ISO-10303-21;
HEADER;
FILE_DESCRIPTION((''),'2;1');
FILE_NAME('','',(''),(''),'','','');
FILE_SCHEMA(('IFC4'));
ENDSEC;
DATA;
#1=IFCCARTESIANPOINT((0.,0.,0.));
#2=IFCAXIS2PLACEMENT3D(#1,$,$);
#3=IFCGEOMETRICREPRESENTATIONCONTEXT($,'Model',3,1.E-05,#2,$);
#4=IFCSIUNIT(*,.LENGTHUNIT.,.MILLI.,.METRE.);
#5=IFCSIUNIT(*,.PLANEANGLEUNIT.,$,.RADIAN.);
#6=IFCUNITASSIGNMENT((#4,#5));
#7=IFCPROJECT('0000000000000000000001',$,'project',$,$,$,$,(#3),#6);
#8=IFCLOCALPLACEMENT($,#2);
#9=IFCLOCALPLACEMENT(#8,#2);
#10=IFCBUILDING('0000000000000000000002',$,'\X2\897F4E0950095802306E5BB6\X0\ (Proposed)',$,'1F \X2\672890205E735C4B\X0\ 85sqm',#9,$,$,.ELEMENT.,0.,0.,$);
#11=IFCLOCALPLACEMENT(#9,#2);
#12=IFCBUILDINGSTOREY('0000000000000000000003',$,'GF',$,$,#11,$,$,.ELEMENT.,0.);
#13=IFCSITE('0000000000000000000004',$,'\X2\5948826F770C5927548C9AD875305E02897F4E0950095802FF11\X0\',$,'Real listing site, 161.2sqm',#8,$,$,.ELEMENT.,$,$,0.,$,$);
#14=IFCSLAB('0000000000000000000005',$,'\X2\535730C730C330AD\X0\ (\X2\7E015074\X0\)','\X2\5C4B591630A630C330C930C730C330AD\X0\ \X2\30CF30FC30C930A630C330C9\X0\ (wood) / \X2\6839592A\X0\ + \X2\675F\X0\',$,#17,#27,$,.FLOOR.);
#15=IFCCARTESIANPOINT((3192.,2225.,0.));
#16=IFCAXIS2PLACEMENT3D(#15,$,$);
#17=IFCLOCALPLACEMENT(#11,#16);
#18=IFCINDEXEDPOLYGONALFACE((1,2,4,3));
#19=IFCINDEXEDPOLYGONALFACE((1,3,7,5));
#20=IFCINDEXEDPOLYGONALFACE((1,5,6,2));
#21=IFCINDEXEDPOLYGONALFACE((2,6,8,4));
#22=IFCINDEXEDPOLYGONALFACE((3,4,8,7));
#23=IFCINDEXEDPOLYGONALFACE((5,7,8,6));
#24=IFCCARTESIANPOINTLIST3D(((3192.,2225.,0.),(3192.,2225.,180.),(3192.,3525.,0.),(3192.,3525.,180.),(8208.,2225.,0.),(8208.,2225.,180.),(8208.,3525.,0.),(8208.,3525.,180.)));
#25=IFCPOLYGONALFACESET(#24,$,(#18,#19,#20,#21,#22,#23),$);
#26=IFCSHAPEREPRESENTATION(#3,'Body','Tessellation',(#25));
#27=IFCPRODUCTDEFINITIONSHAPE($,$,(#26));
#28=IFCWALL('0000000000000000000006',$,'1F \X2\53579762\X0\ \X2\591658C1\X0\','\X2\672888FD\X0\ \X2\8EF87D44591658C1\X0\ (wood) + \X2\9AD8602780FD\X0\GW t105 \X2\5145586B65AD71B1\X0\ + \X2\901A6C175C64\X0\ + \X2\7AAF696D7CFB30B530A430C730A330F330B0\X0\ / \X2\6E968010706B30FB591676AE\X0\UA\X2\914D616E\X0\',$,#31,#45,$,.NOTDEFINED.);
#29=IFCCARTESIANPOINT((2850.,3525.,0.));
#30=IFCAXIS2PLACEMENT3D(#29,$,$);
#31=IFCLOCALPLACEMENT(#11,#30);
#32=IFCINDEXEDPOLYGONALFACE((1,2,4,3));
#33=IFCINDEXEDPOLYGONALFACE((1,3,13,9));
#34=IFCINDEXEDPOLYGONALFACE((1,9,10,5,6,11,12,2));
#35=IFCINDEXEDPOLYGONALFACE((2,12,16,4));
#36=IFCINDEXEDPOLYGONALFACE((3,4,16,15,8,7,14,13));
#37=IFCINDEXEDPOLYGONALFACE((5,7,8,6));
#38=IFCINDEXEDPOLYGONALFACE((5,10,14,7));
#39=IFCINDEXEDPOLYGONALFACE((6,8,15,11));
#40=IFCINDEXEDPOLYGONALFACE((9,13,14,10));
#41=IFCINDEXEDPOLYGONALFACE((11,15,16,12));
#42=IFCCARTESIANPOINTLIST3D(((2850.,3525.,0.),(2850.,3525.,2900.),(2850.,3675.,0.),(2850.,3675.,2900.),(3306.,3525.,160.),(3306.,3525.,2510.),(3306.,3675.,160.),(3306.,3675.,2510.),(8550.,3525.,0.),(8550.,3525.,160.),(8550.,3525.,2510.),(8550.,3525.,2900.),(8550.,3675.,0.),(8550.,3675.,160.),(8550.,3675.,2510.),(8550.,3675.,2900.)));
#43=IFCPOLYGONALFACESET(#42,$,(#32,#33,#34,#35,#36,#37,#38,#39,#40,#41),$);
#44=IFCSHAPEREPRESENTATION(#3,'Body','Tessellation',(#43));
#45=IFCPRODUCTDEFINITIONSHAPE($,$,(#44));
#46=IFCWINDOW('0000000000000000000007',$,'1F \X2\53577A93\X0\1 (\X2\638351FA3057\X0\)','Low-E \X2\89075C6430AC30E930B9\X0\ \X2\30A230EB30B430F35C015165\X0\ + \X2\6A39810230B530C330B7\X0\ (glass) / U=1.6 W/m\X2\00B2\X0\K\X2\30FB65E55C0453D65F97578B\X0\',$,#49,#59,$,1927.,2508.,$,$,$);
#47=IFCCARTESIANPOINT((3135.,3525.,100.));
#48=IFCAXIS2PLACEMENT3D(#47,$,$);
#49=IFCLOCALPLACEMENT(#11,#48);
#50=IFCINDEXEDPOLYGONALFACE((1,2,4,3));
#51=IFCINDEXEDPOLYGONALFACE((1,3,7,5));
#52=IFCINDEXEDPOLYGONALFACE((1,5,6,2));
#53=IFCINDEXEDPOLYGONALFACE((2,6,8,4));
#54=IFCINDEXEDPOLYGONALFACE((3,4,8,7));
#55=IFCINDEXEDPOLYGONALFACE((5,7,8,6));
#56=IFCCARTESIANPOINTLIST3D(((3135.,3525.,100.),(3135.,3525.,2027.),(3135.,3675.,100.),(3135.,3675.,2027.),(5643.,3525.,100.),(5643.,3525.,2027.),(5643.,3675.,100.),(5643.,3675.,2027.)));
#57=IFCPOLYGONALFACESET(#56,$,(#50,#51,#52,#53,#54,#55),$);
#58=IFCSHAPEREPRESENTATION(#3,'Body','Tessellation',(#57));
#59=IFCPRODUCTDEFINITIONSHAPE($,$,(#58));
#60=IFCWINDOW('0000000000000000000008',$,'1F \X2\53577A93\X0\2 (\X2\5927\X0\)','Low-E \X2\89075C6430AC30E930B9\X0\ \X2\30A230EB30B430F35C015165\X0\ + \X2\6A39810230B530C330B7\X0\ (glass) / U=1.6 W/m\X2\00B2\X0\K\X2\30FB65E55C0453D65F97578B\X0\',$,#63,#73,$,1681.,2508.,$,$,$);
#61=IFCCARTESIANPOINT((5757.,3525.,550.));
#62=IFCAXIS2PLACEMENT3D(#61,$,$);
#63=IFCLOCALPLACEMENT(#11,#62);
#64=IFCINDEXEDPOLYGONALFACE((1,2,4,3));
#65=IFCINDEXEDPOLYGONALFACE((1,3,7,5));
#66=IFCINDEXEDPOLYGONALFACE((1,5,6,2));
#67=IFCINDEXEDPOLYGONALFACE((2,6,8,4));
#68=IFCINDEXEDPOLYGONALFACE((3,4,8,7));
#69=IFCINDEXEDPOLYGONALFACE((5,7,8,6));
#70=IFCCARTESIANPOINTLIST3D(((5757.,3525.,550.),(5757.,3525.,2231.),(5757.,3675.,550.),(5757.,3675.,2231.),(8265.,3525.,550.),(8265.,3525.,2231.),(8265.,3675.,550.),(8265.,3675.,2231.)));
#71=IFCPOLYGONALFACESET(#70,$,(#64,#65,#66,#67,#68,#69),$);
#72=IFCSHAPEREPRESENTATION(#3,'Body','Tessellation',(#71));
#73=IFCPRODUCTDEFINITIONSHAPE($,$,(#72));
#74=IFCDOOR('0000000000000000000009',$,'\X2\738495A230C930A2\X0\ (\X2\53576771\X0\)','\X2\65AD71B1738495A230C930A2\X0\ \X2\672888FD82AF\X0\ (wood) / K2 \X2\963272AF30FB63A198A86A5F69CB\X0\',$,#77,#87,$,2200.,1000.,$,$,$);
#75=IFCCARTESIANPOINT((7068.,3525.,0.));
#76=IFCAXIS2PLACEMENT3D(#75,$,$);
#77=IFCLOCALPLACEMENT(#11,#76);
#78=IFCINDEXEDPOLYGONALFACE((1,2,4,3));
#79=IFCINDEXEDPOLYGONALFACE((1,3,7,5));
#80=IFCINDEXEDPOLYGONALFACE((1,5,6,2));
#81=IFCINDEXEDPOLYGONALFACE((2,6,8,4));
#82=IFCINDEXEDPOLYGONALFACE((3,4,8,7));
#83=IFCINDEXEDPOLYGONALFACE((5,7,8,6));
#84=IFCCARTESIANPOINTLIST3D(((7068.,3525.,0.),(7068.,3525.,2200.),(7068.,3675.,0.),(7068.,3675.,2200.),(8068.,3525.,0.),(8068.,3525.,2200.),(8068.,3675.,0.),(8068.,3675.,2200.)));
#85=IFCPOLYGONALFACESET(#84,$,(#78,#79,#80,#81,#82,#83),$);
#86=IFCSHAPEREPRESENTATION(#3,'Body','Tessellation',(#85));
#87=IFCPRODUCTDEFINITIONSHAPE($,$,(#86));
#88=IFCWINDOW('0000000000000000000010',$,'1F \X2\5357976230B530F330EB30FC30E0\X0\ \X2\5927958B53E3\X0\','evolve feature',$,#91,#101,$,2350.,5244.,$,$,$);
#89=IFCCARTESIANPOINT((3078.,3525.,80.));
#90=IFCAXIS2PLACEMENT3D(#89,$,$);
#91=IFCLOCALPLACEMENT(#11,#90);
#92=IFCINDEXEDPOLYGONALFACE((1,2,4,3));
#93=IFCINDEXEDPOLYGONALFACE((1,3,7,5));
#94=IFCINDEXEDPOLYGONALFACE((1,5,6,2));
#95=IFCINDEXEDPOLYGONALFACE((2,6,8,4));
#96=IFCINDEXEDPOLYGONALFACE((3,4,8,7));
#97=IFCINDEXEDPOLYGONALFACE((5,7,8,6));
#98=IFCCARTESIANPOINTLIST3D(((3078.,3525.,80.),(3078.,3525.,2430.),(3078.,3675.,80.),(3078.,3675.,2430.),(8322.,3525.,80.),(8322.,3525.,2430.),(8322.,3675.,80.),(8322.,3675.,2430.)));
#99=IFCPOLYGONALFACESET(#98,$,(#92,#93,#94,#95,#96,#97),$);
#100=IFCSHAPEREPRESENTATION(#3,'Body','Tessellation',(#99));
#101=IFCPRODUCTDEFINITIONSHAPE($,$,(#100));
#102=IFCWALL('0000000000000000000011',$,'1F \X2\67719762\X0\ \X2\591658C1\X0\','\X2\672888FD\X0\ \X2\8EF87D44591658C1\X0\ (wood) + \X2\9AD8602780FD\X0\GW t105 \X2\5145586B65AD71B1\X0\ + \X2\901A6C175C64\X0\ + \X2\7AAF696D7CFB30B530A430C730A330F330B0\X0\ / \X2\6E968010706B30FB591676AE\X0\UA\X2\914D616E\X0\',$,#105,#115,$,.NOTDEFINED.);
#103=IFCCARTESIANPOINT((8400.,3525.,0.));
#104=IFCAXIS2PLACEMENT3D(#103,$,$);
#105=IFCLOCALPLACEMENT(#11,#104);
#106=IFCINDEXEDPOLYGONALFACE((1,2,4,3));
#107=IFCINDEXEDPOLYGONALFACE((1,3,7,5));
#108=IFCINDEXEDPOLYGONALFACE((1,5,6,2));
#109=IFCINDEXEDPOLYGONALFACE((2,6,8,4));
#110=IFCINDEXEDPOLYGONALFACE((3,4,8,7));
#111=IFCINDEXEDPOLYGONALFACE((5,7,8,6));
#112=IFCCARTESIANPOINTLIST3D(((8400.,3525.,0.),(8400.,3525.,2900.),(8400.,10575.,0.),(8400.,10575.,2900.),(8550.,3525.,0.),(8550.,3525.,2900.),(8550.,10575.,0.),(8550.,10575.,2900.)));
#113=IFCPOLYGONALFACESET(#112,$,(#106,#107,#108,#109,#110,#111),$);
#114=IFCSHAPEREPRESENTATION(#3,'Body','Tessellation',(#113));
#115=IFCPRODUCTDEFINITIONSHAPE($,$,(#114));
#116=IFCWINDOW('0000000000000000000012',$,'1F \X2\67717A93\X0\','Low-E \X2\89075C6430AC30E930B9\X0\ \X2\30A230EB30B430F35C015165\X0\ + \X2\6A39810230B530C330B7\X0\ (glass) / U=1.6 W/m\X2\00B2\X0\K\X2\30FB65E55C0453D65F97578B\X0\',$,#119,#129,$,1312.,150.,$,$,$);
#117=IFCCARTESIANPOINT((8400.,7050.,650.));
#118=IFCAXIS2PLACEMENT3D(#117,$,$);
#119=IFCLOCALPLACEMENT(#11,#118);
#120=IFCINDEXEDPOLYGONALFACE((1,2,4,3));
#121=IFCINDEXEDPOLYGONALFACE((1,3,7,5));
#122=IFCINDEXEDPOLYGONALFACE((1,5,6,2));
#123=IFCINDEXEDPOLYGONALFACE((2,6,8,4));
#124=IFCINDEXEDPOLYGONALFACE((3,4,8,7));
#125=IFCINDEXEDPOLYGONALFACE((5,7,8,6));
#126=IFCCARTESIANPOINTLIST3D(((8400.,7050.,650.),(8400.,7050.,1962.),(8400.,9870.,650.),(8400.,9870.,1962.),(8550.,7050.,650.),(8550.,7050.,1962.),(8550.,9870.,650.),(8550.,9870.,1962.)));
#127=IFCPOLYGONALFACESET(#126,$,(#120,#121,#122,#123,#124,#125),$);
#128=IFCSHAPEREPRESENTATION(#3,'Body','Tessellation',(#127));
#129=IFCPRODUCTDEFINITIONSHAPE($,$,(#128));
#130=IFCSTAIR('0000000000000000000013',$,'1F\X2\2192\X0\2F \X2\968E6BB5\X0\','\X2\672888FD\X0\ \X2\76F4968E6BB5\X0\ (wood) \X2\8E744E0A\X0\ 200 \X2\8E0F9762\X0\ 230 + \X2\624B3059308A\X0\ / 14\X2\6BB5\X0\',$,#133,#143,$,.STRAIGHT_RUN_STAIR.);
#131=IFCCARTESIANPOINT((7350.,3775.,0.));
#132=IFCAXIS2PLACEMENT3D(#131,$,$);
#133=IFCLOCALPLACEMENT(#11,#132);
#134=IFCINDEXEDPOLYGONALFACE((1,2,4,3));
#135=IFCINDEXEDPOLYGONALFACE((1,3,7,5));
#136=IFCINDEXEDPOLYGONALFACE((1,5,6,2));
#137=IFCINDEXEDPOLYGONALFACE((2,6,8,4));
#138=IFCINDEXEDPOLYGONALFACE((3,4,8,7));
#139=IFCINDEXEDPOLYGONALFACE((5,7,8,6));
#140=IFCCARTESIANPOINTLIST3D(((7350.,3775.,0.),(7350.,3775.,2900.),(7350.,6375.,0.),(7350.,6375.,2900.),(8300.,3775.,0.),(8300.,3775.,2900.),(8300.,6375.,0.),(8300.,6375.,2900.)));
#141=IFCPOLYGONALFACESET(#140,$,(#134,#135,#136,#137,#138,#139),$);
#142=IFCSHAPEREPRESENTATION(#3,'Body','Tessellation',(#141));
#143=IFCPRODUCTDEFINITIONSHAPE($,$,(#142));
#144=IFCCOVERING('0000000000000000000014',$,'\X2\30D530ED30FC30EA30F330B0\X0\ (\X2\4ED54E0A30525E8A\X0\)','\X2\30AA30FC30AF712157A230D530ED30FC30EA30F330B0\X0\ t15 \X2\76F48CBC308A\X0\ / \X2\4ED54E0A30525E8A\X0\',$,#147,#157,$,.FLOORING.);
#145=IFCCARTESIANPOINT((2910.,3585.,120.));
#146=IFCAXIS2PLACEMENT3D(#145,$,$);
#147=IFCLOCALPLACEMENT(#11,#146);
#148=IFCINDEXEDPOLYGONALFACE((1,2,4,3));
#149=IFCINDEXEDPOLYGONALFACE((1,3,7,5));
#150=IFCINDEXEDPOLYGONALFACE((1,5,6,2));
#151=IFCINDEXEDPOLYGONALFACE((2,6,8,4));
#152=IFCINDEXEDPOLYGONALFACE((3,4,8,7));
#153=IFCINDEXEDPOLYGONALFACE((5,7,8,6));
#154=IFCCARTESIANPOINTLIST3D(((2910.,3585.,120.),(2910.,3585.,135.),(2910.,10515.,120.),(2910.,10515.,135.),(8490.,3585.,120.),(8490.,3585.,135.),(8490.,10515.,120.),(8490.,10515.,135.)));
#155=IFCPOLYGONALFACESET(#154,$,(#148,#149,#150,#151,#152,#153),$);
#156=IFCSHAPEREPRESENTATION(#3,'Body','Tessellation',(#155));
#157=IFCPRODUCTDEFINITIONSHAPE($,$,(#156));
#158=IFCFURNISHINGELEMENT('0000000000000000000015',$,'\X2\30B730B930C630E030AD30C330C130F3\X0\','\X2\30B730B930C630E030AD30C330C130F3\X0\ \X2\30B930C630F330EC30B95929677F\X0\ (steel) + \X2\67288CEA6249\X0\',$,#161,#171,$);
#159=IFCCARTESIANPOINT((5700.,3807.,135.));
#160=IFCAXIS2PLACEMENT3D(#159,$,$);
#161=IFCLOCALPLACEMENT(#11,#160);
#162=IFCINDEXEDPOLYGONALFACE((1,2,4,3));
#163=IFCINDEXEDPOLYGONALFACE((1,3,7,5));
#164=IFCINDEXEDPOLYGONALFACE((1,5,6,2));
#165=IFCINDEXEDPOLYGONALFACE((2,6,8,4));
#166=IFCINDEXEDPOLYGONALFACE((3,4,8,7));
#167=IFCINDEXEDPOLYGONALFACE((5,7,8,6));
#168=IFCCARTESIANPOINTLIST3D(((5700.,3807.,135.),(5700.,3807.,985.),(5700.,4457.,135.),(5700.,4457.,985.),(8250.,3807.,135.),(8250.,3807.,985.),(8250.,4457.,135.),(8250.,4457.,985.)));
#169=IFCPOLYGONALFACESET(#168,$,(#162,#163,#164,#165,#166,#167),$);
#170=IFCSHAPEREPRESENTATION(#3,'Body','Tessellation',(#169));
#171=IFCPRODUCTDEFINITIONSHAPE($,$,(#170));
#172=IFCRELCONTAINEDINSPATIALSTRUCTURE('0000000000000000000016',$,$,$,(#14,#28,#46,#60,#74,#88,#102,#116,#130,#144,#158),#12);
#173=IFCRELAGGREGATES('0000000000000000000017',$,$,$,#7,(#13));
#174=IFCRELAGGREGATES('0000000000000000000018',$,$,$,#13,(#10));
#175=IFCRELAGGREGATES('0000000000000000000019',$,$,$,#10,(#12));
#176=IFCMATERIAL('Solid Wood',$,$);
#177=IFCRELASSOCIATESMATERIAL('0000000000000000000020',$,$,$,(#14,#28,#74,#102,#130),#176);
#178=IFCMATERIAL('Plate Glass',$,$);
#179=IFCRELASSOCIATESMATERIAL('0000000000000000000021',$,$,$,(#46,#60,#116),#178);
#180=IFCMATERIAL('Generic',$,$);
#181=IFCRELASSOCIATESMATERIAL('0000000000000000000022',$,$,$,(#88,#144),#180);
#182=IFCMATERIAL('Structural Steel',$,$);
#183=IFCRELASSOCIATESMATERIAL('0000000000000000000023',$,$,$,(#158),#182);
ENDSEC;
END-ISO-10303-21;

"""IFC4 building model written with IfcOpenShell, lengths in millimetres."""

from ifc_helpers import new_model, si_unit, frame, frame_2d, origin, place, context, project, spatial, rectangle, extrude, material, element, fill, save


model = new_model("IFC4")

# Units and contexts
model_context = context("Model", 3, precision=1e-05, world=origin())
ifc_project = project(units=[si_unit("LENGTHUNIT", "METRE", prefix="MILLI"), si_unit("PLANEANGLEUNIT", "RADIAN")], contexts=[model_context])

# Site, building, storey
site_placement = place(None, origin())
site = spatial("IfcSite", under=ifc_project, at=site_placement, Name="奈良県大和高田市西三倉堂１", ObjectType="Real listing site, 161.2sqm", CompositionType="ELEMENT", RefElevation=0.0)
building_placement = place(site_placement, origin())
building = spatial("IfcBuilding", under=site, at=building_placement, Name="西三倉堂の家 (Proposed)", ObjectType="1F 木造平屋 85sqm", CompositionType="ELEMENT", ElevationOfRefHeight=0.0, ElevationOfTerrain=0.0)
storey_placement = place(building_placement, origin())
storey = spatial("IfcBuildingStorey", under=building, at=storey_placement, Name="GF", CompositionType="ELEMENT", Elevation=0.0)

# Slab
ifc_material_1 = material(Name="Solid Wood")
slab_1_placement = place(storey_placement, frame((3192.0, 2225.0, 0.0)))
element("IfcSlab", 1, at=slab_1_placement, inside=storey, material=ifc_material_1, Name="南デッキ (縁側)", Description="屋外ウッドデッキ ハードウッド (wood) / 根太 + 束", PredefinedType="FLOOR", context=model_context, shape_type="SweptSolid", body=[
    extrude(rectangle(XDim=5016.0, YDim=1300.0, at=frame_2d((2508.0, 650.0))), frame((3192.0, 2225.0, 0.0)), (0.0, 0.0, 1.0), 180.0),
])
ifc_material_2 = material(Name="Generic")

# Wall, openings, windows, door
wall_1_placement = place(storey_placement, frame((2850.0, 3525.0, 0.0)))
wall_1 = element("IfcWall", 2, at=wall_1_placement, inside=storey, material=ifc_material_1, Name="1F 南面 外壁", Description="木製 軸組外壁 (wood) + 高性能GW t105 充填断熱 + 通気層 + 窯業系サイディング / 準耐火・外皮UA配慮", PredefinedType="NOTDEFINED", context=model_context, shape_type="SweptSolid", body=[
    extrude(rectangle(XDim=5700.0, YDim=150.0, at=frame_2d((2850.0, 75.0))), frame((2850.0, 3525.0, 0.0)), (0.0, 0.0, 1.0), 2900.0),
])
opening_1_placement = place(storey_placement, frame((3135.0, 3525.0, 100.0)))
opening_1 = element("IfcOpeningElement", 3, at=opening_1_placement, cuts=wall_1, PredefinedType="NOTDEFINED", context=model_context, shape_type="SweptSolid", body=[
    extrude(rectangle(XDim=2508.0, YDim=150.0, at=frame_2d((1254.0, 75.0))), frame((3135.0, 3525.0, 100.0)), (0.0, 0.0, 1.0), 1927.0),
])
opening_2_placement = place(storey_placement, frame((5757.0, 3525.0, 550.0)))
opening_2 = element("IfcOpeningElement", 4, at=opening_2_placement, cuts=wall_1, PredefinedType="NOTDEFINED", context=model_context, shape_type="SweptSolid", body=[
    extrude(rectangle(XDim=2508.0, YDim=150.0, at=frame_2d((1254.0, 75.0))), frame((5757.0, 3525.0, 550.0)), (0.0, 0.0, 1.0), 1681.0),
])
opening_3_placement = place(storey_placement, frame((7068.0, 3525.0, 0.0)))
opening_3 = element("IfcOpeningElement", 5, at=opening_3_placement, cuts=wall_1, PredefinedType="NOTDEFINED", context=model_context, shape_type="SweptSolid", body=[
    extrude(rectangle(XDim=1000.0, YDim=150.0, at=frame_2d((500.0, 75.0))), frame((7068.0, 3525.0, 0.0)), (0.0, 0.0, 1.0), 2200.0),
])
opening_4_placement = place(storey_placement, frame((3078.0, 3525.0, 80.0)))
opening_4 = element("IfcOpeningElement", 6, at=opening_4_placement, cuts=wall_1, PredefinedType="NOTDEFINED", context=model_context, shape_type="SweptSolid", body=[
    extrude(rectangle(XDim=5244.0, YDim=150.0, at=frame_2d((2622.0, 75.0))), frame((3078.0, 3525.0, 80.0)), (0.0, 0.0, 1.0), 2350.0),
])
ifc_material_3 = material(Name="Plate Glass")
window_1_placement = place(storey_placement, frame((3135.0, 3525.0, 100.0)))
window_1 = element("IfcWindow", 7, at=window_1_placement, inside=storey, material=ifc_material_3, Name="1F 南窓1 (掃出し)", Description="Low-E 複層ガラス アルゴン封入 + 樹脂サッシ (glass) / U=1.6 W/m²K・日射取得型", OverallHeight=1927.0, OverallWidth=2508.0, context=model_context, shape_type="SweptSolid", body=[
    extrude(rectangle(XDim=2508.0, YDim=150.0, at=frame_2d((1254.0, 75.0))), frame((3135.0, 3525.0, 100.0)), (0.0, 0.0, 1.0), 1927.0),
])
fill(opening_1, window_1)
window_2_placement = place(storey_placement, frame((5757.0, 3525.0, 550.0)))
window_2 = element("IfcWindow", 8, at=window_2_placement, inside=storey, material=ifc_material_3, Name="1F 南窓2 (大)", Description="Low-E 複層ガラス アルゴン封入 + 樹脂サッシ (glass) / U=1.6 W/m²K・日射取得型", OverallHeight=1681.0, OverallWidth=2508.0, context=model_context, shape_type="SweptSolid", body=[
    extrude(rectangle(XDim=2508.0, YDim=150.0, at=frame_2d((1254.0, 75.0))), frame((5757.0, 3525.0, 550.0)), (0.0, 0.0, 1.0), 1681.0),
])
fill(opening_2, window_2)
door_placement = place(storey_placement, frame((7068.0, 3525.0, 0.0)))
door = element("IfcDoor", 9, at=door_placement, inside=storey, material=ifc_material_1, Name="玄関ドア (南東)", Description="断熱玄関ドア 木製芯 (wood) / K2 防犯・採風機構", OverallHeight=2200.0, OverallWidth=1000.0, context=model_context, shape_type="SweptSolid", body=[
    extrude(rectangle(XDim=1000.0, YDim=150.0, at=frame_2d((500.0, 75.0))), frame((7068.0, 3525.0, 0.0)), (0.0, 0.0, 1.0), 2200.0),
])
fill(opening_3, door)
window_3_placement = place(storey_placement, frame((3078.0, 3525.0, 80.0)))
window_3 = element("IfcWindow", 10, at=window_3_placement, inside=storey, material=ifc_material_2, Name="1F 南面サンルーム 大開口", Description="evolve feature", OverallHeight=2350.0, OverallWidth=5244.0, context=model_context, shape_type="SweptSolid", body=[
    extrude(rectangle(XDim=5244.0, YDim=150.0, at=frame_2d((2622.0, 75.0))), frame((3078.0, 3525.0, 80.0)), (0.0, 0.0, 1.0), 2350.0),
])
fill(opening_4, window_3)

# Wall, opening, window
wall_2_placement = place(storey_placement, frame((8400.0, 3525.0, 0.0)))
wall_2 = element("IfcWall", 11, at=wall_2_placement, inside=storey, material=ifc_material_1, Name="1F 東面 外壁", Description="木製 軸組外壁 (wood) + 高性能GW t105 充填断熱 + 通気層 + 窯業系サイディング / 準耐火・外皮UA配慮", PredefinedType="NOTDEFINED", context=model_context, shape_type="SweptSolid", body=[
    extrude(rectangle(XDim=150.0, YDim=7050.0, at=frame_2d((75.0, 3525.0))), frame((8400.0, 3525.0, 0.0)), (0.0, 0.0, 1.0), 2900.0),
])
opening_5_placement = place(storey_placement, frame((8400.0, 7050.0, 650.0)))
opening_5 = element("IfcOpeningElement", 12, at=opening_5_placement, cuts=wall_2, PredefinedType="NOTDEFINED", context=model_context, shape_type="SweptSolid", body=[
    extrude(rectangle(XDim=150.0, YDim=2820.0, at=frame_2d((75.0, 1410.0))), frame((8400.0, 7050.0, 650.0)), (0.0, 0.0, 1.0), 1312.0),
])
window_4_placement = place(storey_placement, frame((8400.0, 7050.0, 650.0)))
window_4 = element("IfcWindow", 13, at=window_4_placement, inside=storey, material=ifc_material_3, Name="1F 東窓", Description="Low-E 複層ガラス アルゴン封入 + 樹脂サッシ (glass) / U=1.6 W/m²K・日射取得型", OverallHeight=1312.0, OverallWidth=150.0, context=model_context, shape_type="SweptSolid", body=[
    extrude(rectangle(XDim=150.0, YDim=2820.0, at=frame_2d((75.0, 1410.0))), frame((8400.0, 7050.0, 650.0)), (0.0, 0.0, 1.0), 1312.0),
])
fill(opening_5, window_4)

# Stair
stair_placement = place(storey_placement, frame((7350.0, 3775.0, 0.0)))
element("IfcStair", 14, at=stair_placement, inside=storey, material=ifc_material_1, Name="1F→2F 階段", Description="木製 直階段 (wood) 蹴上 200 踏面 230 + 手すり / 14段", PredefinedType="STRAIGHT_RUN_STAIR", context=model_context, shape_type="SweptSolid", body=[
    extrude(rectangle(XDim=950.0, YDim=2600.0, at=frame_2d((475.0, 1300.0))), frame((7350.0, 3775.0, 0.0)), (0.0, 0.0, 1.0), 2900.0),
])

# Covering
covering_placement = place(storey_placement, frame((2910.0, 3585.0, 120.0)))
element("IfcCovering", 15, at=covering_placement, inside=storey, material=ifc_material_2, Name="フローリング (仕上げ床)", Description="オーク無垢フローリング t15 直貼り / 仕上げ床", PredefinedType="FLOORING", context=model_context, shape_type="SweptSolid", body=[
    extrude(rectangle(XDim=5580.0, YDim=6930.0, at=frame_2d((2790.0, 3465.0))), frame((2910.0, 3585.0, 120.0)), (0.0, 0.0, 1.0), 15.0),
])

# Furnishing element
ifc_material_4 = material(Name="Structural Steel")
furnishing_placement = place(storey_placement, frame((5700.0, 3807.0, 135.0)))
element("IfcFurnishingElement", 16, at=furnishing_placement, inside=storey, material=ifc_material_4, Name="システムキッチン", Description="システムキッチン ステンレス天板 (steel) + 木質扉", context=model_context, shape_type="SweptSolid", body=[
    extrude(rectangle(XDim=2550.0, YDim=650.0, at=frame_2d((1275.0, 325.0))), frame((5700.0, 3807.0, 135.0)), (0.0, 0.0, 1.0), 850.0),
])

save(model, "model.ifc")
